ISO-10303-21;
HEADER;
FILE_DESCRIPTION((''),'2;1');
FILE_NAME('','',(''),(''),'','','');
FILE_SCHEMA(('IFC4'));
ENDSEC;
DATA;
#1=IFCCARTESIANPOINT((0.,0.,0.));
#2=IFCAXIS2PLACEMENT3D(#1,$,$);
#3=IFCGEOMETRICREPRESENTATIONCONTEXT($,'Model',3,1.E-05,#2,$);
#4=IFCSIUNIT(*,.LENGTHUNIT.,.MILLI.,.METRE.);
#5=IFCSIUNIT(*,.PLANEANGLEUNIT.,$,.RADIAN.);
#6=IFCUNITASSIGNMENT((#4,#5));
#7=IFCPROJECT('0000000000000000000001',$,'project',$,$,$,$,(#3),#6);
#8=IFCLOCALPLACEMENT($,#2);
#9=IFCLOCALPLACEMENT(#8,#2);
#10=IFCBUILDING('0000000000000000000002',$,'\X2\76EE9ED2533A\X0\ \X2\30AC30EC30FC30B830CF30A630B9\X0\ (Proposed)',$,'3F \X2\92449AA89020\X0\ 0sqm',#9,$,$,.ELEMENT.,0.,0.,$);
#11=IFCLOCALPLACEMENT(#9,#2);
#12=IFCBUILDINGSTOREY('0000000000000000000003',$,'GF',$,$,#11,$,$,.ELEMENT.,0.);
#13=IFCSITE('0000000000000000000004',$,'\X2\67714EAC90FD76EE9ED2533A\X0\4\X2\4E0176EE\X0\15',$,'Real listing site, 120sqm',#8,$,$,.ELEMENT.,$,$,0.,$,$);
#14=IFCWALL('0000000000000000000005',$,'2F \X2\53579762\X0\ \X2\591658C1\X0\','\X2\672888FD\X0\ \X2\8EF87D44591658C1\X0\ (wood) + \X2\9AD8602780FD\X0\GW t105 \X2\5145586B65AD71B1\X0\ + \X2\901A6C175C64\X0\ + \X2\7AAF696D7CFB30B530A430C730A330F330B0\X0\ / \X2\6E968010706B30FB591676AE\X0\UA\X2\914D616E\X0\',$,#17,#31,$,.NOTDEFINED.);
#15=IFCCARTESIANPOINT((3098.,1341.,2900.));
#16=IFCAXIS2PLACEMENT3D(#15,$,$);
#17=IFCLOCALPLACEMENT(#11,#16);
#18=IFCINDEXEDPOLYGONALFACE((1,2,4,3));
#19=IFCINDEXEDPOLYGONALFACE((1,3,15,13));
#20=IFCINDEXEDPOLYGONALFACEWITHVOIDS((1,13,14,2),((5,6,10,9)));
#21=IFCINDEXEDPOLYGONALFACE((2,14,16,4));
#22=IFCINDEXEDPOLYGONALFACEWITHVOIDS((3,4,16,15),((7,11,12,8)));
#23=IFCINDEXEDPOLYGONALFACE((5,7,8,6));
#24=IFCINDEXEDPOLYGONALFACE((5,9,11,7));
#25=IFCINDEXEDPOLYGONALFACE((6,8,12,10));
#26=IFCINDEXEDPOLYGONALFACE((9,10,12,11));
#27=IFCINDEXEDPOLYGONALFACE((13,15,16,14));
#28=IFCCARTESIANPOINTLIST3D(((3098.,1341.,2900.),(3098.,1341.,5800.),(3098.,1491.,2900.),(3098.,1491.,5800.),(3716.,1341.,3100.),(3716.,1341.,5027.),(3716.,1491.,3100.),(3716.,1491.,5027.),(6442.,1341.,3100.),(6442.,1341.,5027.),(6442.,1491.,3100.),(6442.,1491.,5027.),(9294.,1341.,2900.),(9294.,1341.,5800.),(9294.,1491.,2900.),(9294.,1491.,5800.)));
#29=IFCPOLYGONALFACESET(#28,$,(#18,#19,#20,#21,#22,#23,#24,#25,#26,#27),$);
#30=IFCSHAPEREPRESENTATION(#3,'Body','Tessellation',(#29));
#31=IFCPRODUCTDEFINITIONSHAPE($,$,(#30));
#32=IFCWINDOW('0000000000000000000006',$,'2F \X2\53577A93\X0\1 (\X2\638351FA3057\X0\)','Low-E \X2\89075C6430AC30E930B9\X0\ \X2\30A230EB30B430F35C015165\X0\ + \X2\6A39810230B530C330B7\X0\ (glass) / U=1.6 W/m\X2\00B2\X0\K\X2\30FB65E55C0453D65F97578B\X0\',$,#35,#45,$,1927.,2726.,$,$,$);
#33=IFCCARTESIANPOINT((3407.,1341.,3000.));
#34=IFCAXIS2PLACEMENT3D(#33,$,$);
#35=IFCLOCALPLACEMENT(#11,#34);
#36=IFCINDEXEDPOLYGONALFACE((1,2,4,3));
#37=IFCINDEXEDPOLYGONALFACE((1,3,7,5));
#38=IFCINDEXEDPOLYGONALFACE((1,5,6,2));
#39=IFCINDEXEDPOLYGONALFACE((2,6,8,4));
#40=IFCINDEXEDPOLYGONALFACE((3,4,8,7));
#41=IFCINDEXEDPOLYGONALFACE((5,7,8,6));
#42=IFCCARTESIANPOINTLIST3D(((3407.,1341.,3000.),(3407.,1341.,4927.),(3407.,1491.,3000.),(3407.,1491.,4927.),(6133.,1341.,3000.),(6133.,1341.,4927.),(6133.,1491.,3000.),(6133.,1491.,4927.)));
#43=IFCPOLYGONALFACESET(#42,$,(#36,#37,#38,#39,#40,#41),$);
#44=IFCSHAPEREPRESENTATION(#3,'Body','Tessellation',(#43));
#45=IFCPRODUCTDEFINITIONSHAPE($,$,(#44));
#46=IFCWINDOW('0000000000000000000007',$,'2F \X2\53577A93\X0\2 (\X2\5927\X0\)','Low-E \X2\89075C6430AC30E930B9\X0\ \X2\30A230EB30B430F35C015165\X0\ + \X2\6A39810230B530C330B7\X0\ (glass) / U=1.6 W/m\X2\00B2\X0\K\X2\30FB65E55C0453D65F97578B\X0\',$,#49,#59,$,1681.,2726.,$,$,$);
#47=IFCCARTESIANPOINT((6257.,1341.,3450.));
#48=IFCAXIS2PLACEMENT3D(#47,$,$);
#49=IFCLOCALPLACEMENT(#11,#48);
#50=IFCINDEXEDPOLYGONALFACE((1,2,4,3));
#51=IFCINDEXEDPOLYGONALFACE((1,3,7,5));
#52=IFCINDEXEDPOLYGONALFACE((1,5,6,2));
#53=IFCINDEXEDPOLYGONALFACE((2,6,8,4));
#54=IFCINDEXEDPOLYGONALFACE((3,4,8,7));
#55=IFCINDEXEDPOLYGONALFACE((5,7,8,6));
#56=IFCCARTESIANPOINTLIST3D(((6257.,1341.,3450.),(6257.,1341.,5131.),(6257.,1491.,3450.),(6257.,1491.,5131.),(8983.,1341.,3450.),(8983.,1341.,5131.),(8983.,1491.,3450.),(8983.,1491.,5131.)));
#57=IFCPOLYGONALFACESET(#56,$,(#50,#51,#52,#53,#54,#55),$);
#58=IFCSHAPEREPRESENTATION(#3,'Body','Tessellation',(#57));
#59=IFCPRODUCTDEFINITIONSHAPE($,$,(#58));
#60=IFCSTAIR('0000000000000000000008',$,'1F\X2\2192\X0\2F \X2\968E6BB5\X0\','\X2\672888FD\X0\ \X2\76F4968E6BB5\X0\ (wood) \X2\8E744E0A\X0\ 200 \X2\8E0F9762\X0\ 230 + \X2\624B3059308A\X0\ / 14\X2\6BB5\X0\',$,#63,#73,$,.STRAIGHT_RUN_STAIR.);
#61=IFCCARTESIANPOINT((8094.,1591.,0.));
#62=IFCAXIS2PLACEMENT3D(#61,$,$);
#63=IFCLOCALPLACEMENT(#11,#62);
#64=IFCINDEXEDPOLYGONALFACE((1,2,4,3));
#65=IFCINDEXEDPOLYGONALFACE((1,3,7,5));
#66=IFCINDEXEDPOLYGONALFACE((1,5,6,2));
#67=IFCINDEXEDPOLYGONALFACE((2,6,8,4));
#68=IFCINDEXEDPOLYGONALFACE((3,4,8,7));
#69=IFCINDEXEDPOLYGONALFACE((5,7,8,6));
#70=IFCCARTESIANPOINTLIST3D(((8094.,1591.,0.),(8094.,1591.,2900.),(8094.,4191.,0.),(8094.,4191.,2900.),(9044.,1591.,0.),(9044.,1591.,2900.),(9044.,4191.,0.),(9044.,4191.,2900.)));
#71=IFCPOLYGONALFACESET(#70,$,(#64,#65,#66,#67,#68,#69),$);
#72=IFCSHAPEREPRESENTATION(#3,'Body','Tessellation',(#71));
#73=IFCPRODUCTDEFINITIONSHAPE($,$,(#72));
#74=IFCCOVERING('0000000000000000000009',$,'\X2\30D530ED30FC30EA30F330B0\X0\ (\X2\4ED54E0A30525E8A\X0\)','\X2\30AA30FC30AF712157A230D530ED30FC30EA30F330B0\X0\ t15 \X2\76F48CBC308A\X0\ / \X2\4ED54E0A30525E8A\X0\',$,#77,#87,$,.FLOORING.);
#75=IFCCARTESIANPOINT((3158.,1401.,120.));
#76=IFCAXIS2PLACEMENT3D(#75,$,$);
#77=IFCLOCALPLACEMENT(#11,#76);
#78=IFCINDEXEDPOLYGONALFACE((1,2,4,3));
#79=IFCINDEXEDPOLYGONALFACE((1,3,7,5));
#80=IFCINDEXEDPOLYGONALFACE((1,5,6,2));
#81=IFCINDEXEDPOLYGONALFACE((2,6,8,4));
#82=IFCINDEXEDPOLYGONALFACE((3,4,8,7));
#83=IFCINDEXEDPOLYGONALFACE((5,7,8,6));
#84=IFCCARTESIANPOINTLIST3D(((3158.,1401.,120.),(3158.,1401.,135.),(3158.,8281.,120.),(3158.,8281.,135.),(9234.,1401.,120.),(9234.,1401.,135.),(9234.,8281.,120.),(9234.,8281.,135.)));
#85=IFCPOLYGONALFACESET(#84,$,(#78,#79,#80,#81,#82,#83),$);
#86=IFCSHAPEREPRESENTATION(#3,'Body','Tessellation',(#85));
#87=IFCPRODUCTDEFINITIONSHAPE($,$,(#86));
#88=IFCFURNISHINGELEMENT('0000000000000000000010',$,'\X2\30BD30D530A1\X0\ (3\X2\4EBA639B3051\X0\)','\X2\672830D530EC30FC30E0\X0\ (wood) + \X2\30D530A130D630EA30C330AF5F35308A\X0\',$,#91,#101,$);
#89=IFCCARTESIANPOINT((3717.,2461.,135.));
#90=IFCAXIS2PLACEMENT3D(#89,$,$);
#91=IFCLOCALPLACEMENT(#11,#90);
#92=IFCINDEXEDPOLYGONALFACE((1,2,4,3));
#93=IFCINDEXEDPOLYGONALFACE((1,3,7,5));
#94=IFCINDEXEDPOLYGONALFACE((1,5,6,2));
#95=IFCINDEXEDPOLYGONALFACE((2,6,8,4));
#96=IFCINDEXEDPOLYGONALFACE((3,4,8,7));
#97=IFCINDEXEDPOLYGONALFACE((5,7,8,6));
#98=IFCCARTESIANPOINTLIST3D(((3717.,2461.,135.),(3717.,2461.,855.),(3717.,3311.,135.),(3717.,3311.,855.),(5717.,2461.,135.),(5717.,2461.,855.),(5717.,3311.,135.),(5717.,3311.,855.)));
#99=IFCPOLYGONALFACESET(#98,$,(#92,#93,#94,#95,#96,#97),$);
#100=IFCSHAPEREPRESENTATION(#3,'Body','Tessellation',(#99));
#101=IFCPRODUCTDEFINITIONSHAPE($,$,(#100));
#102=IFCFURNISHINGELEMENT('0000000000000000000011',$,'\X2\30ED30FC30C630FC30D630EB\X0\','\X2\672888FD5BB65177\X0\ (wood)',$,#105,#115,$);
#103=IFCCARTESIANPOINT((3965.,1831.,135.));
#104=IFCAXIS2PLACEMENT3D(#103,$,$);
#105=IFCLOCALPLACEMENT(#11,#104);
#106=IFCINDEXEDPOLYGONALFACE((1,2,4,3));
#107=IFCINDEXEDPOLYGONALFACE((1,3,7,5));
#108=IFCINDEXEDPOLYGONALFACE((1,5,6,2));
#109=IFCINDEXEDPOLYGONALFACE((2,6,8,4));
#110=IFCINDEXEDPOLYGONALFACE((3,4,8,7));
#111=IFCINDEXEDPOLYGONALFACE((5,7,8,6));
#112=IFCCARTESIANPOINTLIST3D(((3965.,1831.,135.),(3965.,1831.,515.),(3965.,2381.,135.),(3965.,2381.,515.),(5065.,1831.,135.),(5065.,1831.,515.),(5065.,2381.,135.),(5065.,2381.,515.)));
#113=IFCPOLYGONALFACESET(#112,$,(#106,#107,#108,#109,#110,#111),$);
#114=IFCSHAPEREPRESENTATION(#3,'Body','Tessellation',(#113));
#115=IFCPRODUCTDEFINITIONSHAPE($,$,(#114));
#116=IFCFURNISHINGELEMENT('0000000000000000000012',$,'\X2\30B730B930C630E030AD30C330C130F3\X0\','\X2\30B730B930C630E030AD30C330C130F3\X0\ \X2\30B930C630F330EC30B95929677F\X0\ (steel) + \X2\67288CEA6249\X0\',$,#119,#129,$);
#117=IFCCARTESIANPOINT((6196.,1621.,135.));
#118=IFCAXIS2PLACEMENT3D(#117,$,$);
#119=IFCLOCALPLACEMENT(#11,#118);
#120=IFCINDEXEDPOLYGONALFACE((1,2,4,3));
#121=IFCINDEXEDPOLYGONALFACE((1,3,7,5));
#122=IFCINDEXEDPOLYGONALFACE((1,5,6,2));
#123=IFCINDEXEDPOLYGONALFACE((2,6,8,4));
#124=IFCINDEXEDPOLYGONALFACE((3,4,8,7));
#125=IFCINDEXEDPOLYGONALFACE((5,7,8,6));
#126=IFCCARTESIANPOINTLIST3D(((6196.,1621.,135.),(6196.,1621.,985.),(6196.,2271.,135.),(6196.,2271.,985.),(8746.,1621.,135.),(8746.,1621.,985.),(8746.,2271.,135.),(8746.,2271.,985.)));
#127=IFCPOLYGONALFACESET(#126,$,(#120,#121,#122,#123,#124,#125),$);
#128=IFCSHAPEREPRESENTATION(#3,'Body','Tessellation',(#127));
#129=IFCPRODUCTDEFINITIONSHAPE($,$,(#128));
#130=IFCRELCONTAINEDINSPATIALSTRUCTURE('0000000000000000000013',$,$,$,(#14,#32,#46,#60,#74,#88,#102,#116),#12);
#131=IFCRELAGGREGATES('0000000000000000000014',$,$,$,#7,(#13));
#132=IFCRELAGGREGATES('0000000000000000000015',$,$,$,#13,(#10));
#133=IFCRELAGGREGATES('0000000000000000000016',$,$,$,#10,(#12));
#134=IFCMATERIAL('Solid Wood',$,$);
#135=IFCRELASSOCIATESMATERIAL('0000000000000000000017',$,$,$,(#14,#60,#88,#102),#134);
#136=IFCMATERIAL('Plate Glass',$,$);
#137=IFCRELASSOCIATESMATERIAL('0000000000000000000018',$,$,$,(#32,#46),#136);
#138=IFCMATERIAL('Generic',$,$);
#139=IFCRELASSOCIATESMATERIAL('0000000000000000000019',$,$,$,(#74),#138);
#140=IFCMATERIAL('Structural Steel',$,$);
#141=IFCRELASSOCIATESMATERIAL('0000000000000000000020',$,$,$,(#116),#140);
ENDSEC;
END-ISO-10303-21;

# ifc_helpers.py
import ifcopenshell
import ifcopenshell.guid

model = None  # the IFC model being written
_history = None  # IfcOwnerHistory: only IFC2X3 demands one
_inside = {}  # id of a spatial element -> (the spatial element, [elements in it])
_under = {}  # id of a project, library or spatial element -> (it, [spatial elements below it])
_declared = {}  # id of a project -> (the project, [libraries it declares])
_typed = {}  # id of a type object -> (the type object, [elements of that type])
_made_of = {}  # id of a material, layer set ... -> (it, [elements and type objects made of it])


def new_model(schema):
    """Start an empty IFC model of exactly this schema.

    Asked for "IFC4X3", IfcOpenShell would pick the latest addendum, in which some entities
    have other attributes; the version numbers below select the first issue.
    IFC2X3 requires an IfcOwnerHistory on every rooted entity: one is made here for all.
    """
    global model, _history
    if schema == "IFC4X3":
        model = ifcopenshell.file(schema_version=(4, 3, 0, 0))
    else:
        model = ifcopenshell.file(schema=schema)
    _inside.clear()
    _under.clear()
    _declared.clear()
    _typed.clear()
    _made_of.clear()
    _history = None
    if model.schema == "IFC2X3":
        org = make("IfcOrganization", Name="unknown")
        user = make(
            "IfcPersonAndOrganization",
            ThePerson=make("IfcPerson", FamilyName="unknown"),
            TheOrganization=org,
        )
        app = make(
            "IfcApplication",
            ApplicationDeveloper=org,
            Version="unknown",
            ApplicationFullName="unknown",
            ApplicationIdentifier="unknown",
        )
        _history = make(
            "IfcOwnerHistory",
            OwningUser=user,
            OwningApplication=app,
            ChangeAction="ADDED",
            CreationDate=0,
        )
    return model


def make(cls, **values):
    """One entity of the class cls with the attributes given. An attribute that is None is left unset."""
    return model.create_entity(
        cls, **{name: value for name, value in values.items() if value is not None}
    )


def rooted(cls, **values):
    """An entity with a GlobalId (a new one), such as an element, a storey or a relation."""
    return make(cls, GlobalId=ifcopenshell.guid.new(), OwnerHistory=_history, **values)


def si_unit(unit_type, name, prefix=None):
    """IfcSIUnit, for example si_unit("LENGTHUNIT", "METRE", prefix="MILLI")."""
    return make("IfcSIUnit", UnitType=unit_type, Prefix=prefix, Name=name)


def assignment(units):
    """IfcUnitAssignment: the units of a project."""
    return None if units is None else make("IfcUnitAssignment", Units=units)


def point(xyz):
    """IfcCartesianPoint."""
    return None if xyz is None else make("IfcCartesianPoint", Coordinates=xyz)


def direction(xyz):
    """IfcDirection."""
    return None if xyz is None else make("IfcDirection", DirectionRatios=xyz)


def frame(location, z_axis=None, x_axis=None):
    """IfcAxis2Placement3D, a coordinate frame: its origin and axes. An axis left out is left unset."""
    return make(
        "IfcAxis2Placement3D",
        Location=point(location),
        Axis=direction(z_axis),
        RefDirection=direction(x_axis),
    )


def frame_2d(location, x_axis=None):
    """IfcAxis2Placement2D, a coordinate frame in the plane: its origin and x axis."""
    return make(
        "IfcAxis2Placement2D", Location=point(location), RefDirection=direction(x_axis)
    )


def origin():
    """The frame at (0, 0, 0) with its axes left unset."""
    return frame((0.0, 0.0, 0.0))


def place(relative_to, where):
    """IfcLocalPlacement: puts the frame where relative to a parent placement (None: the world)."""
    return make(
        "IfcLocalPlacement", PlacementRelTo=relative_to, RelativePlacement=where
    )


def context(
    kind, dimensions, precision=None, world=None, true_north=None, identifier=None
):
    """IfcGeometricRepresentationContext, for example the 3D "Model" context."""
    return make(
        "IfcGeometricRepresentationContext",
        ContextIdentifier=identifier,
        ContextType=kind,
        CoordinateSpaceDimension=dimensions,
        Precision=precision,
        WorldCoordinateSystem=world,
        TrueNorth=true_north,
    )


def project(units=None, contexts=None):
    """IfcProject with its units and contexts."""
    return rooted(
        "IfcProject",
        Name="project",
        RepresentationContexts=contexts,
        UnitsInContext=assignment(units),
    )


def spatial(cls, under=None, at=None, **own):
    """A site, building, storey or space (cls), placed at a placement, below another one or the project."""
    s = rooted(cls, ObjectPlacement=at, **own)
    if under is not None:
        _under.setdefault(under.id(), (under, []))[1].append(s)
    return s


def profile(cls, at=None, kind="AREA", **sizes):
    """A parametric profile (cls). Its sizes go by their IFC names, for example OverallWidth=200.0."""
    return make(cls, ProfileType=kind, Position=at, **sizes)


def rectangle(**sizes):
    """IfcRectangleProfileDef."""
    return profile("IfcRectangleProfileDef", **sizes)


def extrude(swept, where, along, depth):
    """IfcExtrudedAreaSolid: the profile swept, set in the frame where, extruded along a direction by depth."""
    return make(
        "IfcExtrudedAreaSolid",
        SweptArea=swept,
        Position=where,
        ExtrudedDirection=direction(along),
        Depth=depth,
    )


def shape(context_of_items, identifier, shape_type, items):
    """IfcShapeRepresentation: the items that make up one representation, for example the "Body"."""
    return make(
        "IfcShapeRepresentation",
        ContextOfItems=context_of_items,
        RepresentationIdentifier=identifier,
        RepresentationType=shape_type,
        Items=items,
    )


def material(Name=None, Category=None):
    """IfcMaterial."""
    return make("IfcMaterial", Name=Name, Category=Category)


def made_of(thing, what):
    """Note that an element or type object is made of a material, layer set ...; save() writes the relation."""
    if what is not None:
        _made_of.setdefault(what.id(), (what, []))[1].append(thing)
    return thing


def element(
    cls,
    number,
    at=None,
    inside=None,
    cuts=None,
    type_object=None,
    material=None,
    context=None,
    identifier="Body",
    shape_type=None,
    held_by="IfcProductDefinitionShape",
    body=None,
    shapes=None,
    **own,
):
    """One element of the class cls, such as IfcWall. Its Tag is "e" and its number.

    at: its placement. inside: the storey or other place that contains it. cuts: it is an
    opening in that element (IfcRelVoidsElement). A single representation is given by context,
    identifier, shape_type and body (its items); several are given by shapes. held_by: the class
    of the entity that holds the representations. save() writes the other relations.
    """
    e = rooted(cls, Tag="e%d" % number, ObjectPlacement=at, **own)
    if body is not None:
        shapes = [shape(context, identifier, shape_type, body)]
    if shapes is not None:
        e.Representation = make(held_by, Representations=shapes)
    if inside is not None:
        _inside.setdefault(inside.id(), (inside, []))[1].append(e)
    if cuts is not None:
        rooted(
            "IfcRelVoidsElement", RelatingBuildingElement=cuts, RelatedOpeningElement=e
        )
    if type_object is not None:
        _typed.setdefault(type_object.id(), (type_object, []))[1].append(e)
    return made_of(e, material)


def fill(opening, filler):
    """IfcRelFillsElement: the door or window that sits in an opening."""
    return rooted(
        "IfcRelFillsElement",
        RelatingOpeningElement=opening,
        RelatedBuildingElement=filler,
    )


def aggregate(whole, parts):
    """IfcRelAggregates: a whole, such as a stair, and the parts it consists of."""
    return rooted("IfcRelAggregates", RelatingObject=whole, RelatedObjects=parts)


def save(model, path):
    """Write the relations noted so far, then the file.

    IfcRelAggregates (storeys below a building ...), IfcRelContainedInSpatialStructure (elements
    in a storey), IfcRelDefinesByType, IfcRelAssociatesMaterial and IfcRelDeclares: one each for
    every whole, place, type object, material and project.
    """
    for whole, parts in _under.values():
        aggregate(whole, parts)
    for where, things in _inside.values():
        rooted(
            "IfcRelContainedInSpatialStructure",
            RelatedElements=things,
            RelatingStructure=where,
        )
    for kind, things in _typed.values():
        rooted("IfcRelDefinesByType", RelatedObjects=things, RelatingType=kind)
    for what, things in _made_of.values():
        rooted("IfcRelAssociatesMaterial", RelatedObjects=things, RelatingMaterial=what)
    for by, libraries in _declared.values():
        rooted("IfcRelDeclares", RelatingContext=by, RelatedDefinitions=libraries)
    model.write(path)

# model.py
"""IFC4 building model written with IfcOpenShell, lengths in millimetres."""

from ifc_helpers import new_model, si_unit, frame, frame_2d, origin, place, context, project, spatial, rectangle, extrude, material, element, fill, save


model = new_model("IFC4")

# Units and contexts
model_context = context("Model", 3, precision=1e-05, world=origin())
ifc_project = project(units=[si_unit("LENGTHUNIT", "METRE", prefix="MILLI"), si_unit("PLANEANGLEUNIT", "RADIAN")], contexts=[model_context])

# Site, building, storey
site_placement = place(None, origin())
site = spatial("IfcSite", under=ifc_project, at=site_placement, Name="東京都目黒区4丁目15", ObjectType="Real listing site, 120sqm", CompositionType="ELEMENT", RefElevation=0.0)
building_placement = place(site_placement, origin())
building = spatial("IfcBuilding", under=site, at=building_placement, Name="目黒区 ガレージハウス (Proposed)", ObjectType="3F 鉄骨造 0sqm", CompositionType="ELEMENT", ElevationOfRefHeight=0.0, ElevationOfTerrain=0.0)
storey_placement = place(building_placement, origin())
storey = spatial("IfcBuildingStorey", under=building, at=storey_placement, Name="GF", CompositionType="ELEMENT", Elevation=0.0)

# Shared definitions
ifc_material_1 = material(Name="Solid Wood")

# Shared definitions
ifc_material_2 = material(Name="Plate Glass")

# Wall, openings, windows
wall_1_placement = place(storey_placement, frame((3098.0, 1341.0, 2900.0)))
wall_1 = element("IfcWall", 1, at=wall_1_placement, inside=storey, material=ifc_material_1, Name="2F 南面 外壁", Description="木製 軸組外壁 (wood) + 高性能GW t105 充填断熱 + 通気層 + 窯業系サイディング / 準耐火・外皮UA配慮", PredefinedType="NOTDEFINED", context=model_context, shape_type="SweptSolid", body=[
    extrude(rectangle(XDim=6196.0, YDim=150.0, at=frame_2d((3098.0, 75.0))), frame((3098.0, 1341.0, 2900.0)), (0.0, 0.0, 1.0), 2900.0),
])
opening_1_placement = place(storey_placement, frame((3407.0, 1341.0, 3000.0)))
opening_1 = element("IfcOpeningElement", 2, at=opening_1_placement, cuts=wall_1, PredefinedType="NOTDEFINED", context=model_context, shape_type="SweptSolid", body=[
    extrude(rectangle(XDim=2726.0, YDim=150.0, at=frame_2d((1363.0, 75.0))), frame((3407.0, 1341.0, 3000.0)), (0.0, 0.0, 1.0), 1927.0),
])
opening_2_placement = place(storey_placement, frame((6257.0, 1341.0, 3450.0)))
opening_2 = element("IfcOpeningElement", 3, at=opening_2_placement, cuts=wall_1, PredefinedType="NOTDEFINED", context=model_context, shape_type="SweptSolid", body=[
    extrude(rectangle(XDim=2726.0, YDim=150.0, at=frame_2d((1363.0, 75.0))), frame((6257.0, 1341.0, 3450.0)), (0.0, 0.0, 1.0), 1681.0),
])
window_1_placement = place(storey_placement, frame((3407.0, 1341.0, 3000.0)))
window_1 = element("IfcWindow", 4, at=window_1_placement, inside=storey, material=ifc_material_2, Name="2F 南窓1 (掃出し)", Description="Low-E 複層ガラス アルゴン封入 + 樹脂サッシ (glass) / U=1.6 W/m²K・日射取得型", OverallHeight=1927.0, OverallWidth=2726.0, context=model_context, shape_type="SweptSolid", body=[
    extrude(rectangle(XDim=2726.0, YDim=150.0, at=frame_2d((1363.0, 75.0))), frame((3407.0, 1341.0, 3000.0)), (0.0, 0.0, 1.0), 1927.0),
])
fill(opening_1, window_1)
window_2_placement = place(storey_placement, frame((6257.0, 1341.0, 3450.0)))
window_2 = element("IfcWindow", 5, at=window_2_placement, inside=storey, material=ifc_material_2, Name="2F 南窓2 (大)", Description="Low-E 複層ガラス アルゴン封入 + 樹脂サッシ (glass) / U=1.6 W/m²K・日射取得型", OverallHeight=1681.0, OverallWidth=2726.0, context=model_context, shape_type="SweptSolid", body=[
    extrude(rectangle(XDim=2726.0, YDim=150.0, at=frame_2d((1363.0, 75.0))), frame((6257.0, 1341.0, 3450.0)), (0.0, 0.0, 1.0), 1681.0),
])
fill(opening_2, window_2)

# Stair
stair_placement = place(storey_placement, frame((8094.0, 1591.0, 0.0)))
element("IfcStair", 6, at=stair_placement, inside=storey, material=ifc_material_1, Name="1F→2F 階段", Description="木製 直階段 (wood) 蹴上 200 踏面 230 + 手すり / 14段", PredefinedType="STRAIGHT_RUN_STAIR", context=model_context, shape_type="SweptSolid", body=[
    extrude(rectangle(XDim=950.0, YDim=2600.0, at=frame_2d((475.0, 1300.0))), frame((8094.0, 1591.0, 0.0)), (0.0, 0.0, 1.0), 2900.0),
])

# Covering
ifc_material_3 = material(Name="Generic")
covering_placement = place(storey_placement, frame((3158.0, 1401.0, 120.0)))
element("IfcCovering", 7, at=covering_placement, inside=storey, material=ifc_material_3, Name="フローリング (仕上げ床)", Description="オーク無垢フローリング t15 直貼り / 仕上げ床", PredefinedType="FLOORING", context=model_context, shape_type="SweptSolid", body=[
    extrude(rectangle(XDim=6076.0, YDim=6880.0, at=frame_2d((3038.0, 3440.0))), frame((3158.0, 1401.0, 120.0)), (0.0, 0.0, 1.0), 15.0),
])

# Furnishing elements
furnishing_1_placement = place(storey_placement, frame((3717.0, 2461.0, 135.0)))
element("IfcFurnishingElement", 8, at=furnishing_1_placement, inside=storey, material=ifc_material_1, Name="ソファ (3人掛け)", Description="木フレーム (wood) + ファブリック張り", context=model_context, shape_type="SweptSolid", body=[
    extrude(rectangle(XDim=2000.0, YDim=850.0, at=frame_2d((1000.0, 425.0))), frame((3717.0, 2461.0, 135.0)), (0.0, 0.0, 1.0), 720.0),
])
furnishing_2_placement = place(storey_placement, frame((3965.0, 1831.0, 135.0)))
element("IfcFurnishingElement", 9, at=furnishing_2_placement, inside=storey, material=ifc_material_1, Name="ローテーブル", Description="木製家具 (wood)", context=model_context, shape_type="SweptSolid", body=[
    extrude(rectangle(XDim=1100.0, YDim=550.0, at=frame_2d((550.0, 275.0))), frame((3965.0, 1831.0, 135.0)), (0.0, 0.0, 1.0), 380.0),
])
ifc_material_4 = material(Name="Structural Steel")
furnishing_3_placement = place(storey_placement, frame((6196.0, 1621.0, 135.0)))
element("IfcFurnishingElement", 10, at=furnishing_3_placement, inside=storey, material=ifc_material_4, Name="システムキッチン", Description="システムキッチン ステンレス天板 (steel) + 木質扉", context=model_context, shape_type="SweptSolid", body=[
    extrude(rectangle(XDim=2550.0, YDim=650.0, at=frame_2d((1275.0, 325.0))), frame((6196.0, 1621.0, 135.0)), (0.0, 0.0, 1.0), 850.0),
])

save(model, "model.ifc")
